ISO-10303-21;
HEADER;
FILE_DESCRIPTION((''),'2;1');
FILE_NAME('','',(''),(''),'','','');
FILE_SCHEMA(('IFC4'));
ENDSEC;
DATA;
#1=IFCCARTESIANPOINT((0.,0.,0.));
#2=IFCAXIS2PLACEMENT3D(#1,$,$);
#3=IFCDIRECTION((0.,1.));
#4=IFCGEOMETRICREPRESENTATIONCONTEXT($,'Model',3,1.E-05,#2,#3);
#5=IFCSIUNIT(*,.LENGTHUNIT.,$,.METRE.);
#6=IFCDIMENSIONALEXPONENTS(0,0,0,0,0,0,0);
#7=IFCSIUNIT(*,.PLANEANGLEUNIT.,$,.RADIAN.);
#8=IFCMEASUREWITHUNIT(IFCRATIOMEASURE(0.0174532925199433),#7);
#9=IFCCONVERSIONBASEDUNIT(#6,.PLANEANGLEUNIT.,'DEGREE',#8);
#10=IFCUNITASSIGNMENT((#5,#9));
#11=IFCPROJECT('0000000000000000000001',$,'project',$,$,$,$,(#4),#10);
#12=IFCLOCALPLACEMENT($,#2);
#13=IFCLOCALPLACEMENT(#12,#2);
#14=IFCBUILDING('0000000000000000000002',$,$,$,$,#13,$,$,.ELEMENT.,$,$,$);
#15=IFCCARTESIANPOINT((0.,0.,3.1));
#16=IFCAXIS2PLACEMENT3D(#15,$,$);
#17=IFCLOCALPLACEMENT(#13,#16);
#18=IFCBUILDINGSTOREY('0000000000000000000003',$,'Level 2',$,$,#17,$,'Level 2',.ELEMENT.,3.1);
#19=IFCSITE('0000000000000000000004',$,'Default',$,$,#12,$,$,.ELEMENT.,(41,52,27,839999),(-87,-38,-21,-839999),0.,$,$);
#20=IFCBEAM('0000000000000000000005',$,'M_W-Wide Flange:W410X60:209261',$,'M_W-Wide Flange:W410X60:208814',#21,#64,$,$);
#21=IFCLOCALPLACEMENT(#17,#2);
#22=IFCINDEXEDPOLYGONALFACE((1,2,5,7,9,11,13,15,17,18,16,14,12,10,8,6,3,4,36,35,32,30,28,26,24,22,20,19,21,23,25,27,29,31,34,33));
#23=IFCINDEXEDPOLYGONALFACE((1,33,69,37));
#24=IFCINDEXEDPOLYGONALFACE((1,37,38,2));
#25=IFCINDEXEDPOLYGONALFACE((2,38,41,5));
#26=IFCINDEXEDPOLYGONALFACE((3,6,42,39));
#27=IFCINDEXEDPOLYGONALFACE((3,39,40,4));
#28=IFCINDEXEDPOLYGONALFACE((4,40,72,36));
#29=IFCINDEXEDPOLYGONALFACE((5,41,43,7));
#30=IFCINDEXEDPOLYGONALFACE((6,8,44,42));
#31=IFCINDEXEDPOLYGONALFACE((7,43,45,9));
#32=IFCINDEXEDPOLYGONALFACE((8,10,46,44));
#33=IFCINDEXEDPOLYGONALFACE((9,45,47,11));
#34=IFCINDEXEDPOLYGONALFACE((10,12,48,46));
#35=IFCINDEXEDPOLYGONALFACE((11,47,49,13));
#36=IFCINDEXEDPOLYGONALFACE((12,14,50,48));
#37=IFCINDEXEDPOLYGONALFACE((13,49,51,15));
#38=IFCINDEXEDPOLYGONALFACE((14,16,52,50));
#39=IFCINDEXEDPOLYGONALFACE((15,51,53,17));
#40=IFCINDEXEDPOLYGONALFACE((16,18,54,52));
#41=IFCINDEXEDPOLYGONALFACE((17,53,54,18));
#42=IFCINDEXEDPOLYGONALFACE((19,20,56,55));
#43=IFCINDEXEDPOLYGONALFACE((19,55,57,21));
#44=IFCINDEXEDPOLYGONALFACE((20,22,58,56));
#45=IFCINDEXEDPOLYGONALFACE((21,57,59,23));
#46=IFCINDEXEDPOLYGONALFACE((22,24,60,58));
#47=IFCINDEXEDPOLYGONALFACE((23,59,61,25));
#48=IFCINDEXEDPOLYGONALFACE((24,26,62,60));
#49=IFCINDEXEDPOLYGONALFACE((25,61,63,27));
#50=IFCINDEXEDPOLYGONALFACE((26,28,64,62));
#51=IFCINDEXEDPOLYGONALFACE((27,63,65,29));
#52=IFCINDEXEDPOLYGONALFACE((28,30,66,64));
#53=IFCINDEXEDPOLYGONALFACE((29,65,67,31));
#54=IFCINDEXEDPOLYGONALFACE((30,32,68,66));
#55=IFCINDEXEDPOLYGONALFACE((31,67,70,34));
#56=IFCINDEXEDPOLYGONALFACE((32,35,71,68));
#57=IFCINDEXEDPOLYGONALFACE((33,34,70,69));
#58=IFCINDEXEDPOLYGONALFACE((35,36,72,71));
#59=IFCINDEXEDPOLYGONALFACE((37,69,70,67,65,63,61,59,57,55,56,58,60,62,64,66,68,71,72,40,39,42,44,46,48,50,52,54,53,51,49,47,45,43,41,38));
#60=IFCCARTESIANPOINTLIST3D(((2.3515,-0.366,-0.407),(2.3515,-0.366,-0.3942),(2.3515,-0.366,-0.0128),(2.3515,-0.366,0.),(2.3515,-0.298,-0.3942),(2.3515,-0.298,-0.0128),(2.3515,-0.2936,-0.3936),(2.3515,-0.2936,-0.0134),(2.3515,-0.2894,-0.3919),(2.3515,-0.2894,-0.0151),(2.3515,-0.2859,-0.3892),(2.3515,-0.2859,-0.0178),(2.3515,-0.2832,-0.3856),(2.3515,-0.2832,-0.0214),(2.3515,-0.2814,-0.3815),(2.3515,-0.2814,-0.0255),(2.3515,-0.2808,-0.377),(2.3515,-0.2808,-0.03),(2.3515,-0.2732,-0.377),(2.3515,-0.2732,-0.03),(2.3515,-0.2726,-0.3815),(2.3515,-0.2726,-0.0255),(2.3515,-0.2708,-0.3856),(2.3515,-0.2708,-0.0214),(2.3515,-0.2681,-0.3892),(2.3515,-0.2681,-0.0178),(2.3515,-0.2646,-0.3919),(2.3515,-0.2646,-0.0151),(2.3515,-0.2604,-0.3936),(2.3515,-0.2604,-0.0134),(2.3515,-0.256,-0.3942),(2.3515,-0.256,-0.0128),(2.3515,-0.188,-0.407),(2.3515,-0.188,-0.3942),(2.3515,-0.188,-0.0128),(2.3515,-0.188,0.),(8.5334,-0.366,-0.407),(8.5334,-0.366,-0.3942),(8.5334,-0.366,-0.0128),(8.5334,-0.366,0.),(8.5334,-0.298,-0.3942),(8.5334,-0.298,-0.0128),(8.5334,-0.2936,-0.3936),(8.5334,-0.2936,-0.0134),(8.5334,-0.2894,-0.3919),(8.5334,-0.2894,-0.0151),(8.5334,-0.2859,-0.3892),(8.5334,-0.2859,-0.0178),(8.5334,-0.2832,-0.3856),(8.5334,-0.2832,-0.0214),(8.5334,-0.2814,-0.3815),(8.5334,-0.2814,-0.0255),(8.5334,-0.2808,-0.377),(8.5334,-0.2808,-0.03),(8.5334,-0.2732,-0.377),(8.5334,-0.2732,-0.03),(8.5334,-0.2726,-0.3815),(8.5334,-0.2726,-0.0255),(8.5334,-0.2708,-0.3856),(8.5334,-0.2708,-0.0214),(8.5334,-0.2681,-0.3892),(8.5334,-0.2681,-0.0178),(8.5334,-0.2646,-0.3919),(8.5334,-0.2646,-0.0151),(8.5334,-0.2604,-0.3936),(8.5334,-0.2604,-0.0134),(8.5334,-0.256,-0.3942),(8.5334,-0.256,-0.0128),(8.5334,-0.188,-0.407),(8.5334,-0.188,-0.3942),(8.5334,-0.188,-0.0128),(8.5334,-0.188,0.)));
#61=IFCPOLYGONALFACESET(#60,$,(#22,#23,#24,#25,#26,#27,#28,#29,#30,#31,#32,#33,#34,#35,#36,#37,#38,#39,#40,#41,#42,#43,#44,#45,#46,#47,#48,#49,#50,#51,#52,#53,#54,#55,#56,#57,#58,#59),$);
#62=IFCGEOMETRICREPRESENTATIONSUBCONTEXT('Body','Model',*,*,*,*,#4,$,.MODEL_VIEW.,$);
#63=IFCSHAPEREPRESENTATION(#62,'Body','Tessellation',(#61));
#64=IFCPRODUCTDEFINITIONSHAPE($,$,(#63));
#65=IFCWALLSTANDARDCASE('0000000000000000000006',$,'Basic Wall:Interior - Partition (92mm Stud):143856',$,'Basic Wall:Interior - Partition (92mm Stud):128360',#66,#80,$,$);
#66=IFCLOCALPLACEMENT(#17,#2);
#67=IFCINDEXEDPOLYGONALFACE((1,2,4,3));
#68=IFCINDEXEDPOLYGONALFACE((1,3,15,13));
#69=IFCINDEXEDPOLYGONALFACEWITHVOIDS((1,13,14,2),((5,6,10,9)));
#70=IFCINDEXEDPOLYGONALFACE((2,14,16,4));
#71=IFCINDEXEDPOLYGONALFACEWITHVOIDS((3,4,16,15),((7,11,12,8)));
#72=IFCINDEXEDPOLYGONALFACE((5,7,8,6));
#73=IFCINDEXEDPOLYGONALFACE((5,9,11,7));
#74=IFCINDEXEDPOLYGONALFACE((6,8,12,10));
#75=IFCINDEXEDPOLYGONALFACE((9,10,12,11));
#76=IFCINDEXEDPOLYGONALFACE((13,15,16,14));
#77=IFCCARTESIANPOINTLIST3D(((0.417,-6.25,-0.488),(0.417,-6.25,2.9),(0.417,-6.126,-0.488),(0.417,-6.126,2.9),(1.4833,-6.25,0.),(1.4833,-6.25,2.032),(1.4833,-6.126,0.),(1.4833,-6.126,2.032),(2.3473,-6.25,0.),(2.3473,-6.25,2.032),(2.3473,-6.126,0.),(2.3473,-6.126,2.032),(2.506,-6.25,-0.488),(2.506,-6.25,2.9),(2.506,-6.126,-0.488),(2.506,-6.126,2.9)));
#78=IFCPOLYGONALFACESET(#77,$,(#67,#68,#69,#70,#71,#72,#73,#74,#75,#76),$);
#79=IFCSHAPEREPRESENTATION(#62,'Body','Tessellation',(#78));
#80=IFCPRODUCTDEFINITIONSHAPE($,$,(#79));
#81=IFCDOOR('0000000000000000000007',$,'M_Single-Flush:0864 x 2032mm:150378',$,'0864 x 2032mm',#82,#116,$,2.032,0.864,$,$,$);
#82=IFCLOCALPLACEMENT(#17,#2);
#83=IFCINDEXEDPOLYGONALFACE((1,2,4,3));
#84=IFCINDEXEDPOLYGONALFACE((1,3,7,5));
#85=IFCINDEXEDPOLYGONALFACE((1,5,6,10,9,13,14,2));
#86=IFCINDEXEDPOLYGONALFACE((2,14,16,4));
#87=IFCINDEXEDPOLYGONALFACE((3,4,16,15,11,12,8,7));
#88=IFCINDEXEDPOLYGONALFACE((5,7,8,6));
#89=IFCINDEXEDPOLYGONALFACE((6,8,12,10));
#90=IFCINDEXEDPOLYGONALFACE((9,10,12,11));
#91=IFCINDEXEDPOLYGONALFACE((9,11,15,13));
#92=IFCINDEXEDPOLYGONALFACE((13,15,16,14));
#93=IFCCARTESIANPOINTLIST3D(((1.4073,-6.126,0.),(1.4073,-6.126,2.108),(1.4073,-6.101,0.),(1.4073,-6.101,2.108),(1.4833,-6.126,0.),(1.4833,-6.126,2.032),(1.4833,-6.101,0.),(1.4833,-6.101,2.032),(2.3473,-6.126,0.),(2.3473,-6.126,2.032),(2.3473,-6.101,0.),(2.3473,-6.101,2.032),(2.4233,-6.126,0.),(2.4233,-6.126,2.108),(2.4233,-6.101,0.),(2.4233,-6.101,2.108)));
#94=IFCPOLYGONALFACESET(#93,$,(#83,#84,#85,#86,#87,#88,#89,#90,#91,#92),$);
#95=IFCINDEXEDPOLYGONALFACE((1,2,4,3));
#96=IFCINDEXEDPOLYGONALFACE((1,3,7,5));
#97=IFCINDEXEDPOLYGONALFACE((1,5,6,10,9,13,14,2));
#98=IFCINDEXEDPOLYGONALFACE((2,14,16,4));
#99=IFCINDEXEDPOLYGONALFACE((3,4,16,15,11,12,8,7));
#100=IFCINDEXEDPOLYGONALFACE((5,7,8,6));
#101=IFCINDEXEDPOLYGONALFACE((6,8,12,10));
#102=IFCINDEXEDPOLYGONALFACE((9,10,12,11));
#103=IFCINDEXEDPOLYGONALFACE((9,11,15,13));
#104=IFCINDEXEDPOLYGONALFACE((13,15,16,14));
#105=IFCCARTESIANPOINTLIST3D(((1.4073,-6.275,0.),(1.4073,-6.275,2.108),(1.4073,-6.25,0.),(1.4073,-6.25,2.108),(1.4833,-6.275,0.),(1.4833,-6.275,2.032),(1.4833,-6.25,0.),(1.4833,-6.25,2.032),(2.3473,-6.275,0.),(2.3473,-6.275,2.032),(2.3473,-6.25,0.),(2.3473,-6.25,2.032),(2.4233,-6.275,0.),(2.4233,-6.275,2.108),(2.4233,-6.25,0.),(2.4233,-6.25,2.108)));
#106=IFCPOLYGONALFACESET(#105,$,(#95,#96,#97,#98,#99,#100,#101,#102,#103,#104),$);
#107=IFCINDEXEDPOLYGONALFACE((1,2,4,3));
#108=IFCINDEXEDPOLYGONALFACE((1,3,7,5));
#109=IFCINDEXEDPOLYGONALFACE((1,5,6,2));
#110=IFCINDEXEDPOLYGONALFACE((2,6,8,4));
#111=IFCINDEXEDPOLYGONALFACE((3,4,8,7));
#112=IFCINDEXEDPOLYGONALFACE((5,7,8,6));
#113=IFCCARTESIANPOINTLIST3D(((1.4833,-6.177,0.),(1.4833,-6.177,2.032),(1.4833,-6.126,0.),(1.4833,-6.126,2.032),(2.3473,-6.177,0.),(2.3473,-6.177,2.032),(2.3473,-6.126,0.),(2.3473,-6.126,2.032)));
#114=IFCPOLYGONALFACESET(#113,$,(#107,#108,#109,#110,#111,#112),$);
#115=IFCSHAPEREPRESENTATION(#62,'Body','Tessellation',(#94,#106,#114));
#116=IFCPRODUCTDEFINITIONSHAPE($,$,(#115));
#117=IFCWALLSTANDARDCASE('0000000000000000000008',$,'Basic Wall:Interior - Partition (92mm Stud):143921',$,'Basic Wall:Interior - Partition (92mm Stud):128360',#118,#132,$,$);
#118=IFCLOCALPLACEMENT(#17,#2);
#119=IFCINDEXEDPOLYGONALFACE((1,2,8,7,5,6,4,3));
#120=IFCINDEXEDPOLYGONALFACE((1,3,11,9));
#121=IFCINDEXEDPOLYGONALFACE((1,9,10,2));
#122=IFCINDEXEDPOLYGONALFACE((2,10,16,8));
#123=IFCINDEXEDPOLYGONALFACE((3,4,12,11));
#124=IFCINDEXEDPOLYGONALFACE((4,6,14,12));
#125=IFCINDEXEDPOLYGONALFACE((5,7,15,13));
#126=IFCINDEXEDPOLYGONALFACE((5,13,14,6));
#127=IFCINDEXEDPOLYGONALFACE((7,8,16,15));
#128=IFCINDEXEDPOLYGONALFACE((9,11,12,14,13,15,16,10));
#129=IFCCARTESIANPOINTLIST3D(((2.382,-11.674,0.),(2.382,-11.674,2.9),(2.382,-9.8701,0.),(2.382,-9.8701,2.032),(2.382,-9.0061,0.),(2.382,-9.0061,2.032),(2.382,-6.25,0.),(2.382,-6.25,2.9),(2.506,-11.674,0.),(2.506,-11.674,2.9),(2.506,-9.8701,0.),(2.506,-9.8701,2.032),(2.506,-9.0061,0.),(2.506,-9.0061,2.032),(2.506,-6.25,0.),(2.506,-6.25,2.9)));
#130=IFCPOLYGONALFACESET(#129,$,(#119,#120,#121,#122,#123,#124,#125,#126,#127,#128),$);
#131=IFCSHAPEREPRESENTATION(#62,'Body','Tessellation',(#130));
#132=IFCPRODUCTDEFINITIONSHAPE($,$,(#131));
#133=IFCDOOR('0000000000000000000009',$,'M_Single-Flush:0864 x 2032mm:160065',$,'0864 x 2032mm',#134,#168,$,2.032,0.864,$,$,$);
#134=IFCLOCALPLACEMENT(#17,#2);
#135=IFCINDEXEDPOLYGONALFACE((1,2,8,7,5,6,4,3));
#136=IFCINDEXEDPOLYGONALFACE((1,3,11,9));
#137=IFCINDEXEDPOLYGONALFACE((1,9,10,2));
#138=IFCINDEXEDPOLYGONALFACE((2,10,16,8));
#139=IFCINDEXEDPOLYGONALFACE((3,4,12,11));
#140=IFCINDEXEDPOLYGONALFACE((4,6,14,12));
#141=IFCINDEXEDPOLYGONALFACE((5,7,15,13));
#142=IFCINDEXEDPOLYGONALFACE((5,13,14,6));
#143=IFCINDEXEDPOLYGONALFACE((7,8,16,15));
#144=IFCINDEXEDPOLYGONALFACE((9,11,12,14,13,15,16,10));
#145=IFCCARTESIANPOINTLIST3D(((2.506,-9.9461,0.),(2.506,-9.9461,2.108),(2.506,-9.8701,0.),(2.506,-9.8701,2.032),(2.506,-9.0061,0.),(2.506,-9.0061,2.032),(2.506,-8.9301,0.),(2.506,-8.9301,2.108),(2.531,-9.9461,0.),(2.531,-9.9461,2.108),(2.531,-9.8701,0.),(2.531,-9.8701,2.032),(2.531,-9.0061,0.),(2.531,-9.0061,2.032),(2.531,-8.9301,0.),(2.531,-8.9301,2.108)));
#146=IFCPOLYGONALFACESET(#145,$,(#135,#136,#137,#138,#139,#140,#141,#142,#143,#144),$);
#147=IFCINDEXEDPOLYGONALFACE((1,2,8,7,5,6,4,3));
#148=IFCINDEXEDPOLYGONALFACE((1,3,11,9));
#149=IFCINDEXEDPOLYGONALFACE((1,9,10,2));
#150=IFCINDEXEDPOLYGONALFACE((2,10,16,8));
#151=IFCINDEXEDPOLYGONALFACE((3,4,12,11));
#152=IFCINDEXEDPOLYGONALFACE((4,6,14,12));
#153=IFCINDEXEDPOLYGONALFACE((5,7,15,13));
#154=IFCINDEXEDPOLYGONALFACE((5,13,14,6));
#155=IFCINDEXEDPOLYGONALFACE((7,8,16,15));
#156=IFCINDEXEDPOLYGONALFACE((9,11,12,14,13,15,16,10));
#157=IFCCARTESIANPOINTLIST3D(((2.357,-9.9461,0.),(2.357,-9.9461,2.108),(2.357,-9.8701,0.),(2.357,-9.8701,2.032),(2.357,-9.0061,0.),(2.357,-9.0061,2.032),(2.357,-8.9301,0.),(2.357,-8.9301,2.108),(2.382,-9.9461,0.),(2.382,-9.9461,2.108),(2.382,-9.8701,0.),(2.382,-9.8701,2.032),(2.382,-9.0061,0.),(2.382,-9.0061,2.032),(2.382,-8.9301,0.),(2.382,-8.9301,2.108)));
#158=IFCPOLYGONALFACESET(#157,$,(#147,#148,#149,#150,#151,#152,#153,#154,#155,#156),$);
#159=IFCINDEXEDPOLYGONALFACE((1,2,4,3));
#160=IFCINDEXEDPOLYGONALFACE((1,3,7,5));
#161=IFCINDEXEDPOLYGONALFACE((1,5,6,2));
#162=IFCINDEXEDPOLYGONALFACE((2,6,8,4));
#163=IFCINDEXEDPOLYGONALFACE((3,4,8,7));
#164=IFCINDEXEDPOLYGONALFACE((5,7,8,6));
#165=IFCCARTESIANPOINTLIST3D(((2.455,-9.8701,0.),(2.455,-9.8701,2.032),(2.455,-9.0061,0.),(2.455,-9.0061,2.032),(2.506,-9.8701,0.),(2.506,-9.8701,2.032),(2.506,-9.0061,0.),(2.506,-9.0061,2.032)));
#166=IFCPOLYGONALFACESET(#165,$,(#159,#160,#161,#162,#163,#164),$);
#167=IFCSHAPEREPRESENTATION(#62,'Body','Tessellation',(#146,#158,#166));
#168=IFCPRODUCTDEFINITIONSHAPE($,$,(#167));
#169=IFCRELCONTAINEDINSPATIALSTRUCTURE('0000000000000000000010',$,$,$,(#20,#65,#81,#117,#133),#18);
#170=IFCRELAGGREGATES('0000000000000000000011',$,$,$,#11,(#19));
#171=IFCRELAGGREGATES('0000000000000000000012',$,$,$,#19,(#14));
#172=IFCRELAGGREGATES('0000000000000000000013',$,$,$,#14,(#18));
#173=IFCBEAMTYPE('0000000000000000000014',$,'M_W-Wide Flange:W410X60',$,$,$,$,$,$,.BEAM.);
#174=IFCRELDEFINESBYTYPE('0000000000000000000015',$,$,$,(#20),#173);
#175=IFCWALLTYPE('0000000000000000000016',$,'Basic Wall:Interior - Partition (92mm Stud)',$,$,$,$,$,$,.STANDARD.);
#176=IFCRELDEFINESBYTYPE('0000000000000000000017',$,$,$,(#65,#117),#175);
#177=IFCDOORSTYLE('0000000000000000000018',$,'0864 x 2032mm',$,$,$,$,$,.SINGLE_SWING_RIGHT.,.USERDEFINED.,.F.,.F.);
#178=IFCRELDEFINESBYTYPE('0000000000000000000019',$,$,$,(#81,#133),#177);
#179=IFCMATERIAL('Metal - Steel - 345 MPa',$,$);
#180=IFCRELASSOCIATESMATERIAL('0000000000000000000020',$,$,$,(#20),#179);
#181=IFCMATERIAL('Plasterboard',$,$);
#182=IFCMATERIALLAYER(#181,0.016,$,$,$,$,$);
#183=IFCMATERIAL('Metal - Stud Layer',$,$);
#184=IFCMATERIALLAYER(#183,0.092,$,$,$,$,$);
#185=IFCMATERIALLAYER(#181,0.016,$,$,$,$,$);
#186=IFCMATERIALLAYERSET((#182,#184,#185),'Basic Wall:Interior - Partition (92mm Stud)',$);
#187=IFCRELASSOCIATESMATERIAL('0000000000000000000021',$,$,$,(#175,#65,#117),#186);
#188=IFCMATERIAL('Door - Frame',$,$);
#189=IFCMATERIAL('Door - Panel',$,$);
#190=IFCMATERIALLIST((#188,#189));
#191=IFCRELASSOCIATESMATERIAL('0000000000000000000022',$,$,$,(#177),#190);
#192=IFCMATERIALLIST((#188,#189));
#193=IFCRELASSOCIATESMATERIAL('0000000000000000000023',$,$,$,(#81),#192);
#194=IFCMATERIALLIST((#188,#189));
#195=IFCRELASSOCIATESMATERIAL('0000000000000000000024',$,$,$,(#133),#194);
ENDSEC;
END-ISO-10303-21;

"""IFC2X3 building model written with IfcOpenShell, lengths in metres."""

from ifc_helpers import new_model, entity, si_unit, converted_unit, direction, frame, frame_2d, origin, origin_2d_with_axis, place, context, subcontext, project, spatial, polyline, rectangle, i_section, outline, extrude, source, transform, mapped, material, material_list, layer, layer_set, layer_usage, type_object, type_shapes, element, fill, save


model = new_model("IFC2X3")

# Units and contexts
model_context = context("Model", 3, precision=1e-05, world=origin(), true_north=direction((0.0, 1.0)))
body_context = subcontext(model_context, "Body", "Model", "MODEL_VIEW")
ifc_project = project(units=[si_unit("LENGTHUNIT", "METRE"), converted_unit("PLANEANGLEUNIT", "DEGREE", entity("IfcRatioMeasure", 0.0174532925199433), si_unit("PLANEANGLEUNIT", "RADIAN"), dimensions=[0, 0, 0, 0, 0, 0, 0])], contexts=[model_context])

# Site, building, storey
site_placement = place(None, origin())
site = spatial("IfcSite", under=ifc_project, at=site_placement, Name="Default", CompositionType="ELEMENT", RefLatitude=(41, 52, 27, 839999), RefLongitude=(-87, -38, -21, -839999), RefElevation=0.0)
building_placement = place(site_placement, origin())
building = spatial("IfcBuilding", under=site, at=building_placement, CompositionType="ELEMENT")
storey_placement = place(building_placement, frame((0.0, 0.0, 3.1)))
storey = spatial("IfcBuildingStorey", under=building, at=storey_placement, Name="Level 2", LongName="Level 2", CompositionType="ELEMENT", Elevation=3.1)

# Beam
ifc_material_1 = material(Name="Metal - Steel - 345 MPa")
beam_type = type_object("IfcBeamType", Name="M_W-Wide Flange:W410X60", PredefinedType="BEAM")
beam_placement = place(storey_placement, frame((8.5334, -0.277, 0.0), z_axis=(0.0, 0.0, 1.0), x_axis=(-1.0, 0.0, 0.0)))
element("IfcBeam", 1, at=beam_placement, inside=storey, type_object=beam_type, material=ifc_material_1, Name="M_W-Wide Flange:W410X60:209261", ObjectType="M_W-Wide Flange:W410X60:208814", context=body_context, shape_type="SweptSolid", body=[
    extrude(i_section(OverallWidth=0.178, OverallDepth=0.407, WebThickness=0.0077, FlangeThickness=0.0128, FilletRadius=0.0172, at=frame_2d((0.0, 0.0), x_axis=(0.0, 1.0))), frame((0.0, 0.0, -0.2035), z_axis=(1.0, 0.0, 0.0), x_axis=(0.0, 0.0, -1.0)), (0.0, 0.0, 1.0), 6.1819),
])

# Shared definitions
ifc_material_2 = material(Name="Metal - Stud Layer")
ifc_material_3 = material(Name="Plasterboard")

# Walls, openings, doors
ifc_layer_1 = layer(ifc_material_3, 0.016)
ifc_layer_2 = layer(ifc_material_2, 0.092)
ifc_layer_3 = layer(ifc_material_3, 0.016)
ifc_layer_set_1 = layer_set([ifc_layer_1, ifc_layer_2, ifc_layer_3], Name="Basic Wall:Interior - Partition (92mm Stud)")
ifc_layer_usage_1 = layer_usage(ifc_layer_set_1, "AXIS2", "NEGATIVE", 0.062)
wall_type_1 = type_object("IfcWallType", Name="Basic Wall:Interior - Partition (92mm Stud)", PredefinedType="STANDARD", material=ifc_layer_set_1)
wall_1_placement = place(storey_placement, frame((0.417, -6.188, -0.488)))
wall_1 = element("IfcWallStandardCase", 2, at=wall_1_placement, inside=storey, type_object=wall_type_1, material=ifc_layer_usage_1, Name="Basic Wall:Interior - Partition (92mm Stud):143856", ObjectType="Basic Wall:Interior - Partition (92mm Stud):128360", context=body_context, shape_type="SweptSolid", body=[
    extrude(rectangle(XDim=2.089, YDim=0.124, at=frame_2d((1.0445, 0.0), x_axis=(-1.0, 0.0))), origin(), (0.0, 0.0, 1.0), 3.388),
])
opening_1_placement = place(wall_1_placement, frame((1.0663, -0.062, 0.488)))
opening_1 = element("IfcOpeningElement", 3, at=opening_1_placement, cuts=wall_1, ObjectType="Opening", context=body_context, shape_type="SweptSolid", body=[
    extrude(rectangle(XDim=0.864, YDim=2.032, at=frame_2d((1.016, 0.432), x_axis=(0.0, 1.0))), frame((0.0, 0.0, 0.0), z_axis=(0.0, 1.0, 0.0), x_axis=(0.0, 0.0, 1.0)), (0.0, 0.0, 1.0), 0.124),
])
ifc_material_4 = material(Name="Door - Frame")
ifc_material_5 = material(Name="Door - Panel")
ifc_material_list_1 = material_list([ifc_material_4, ifc_material_5])
ifc_material_list_2 = material_list([ifc_material_4, ifc_material_5])
door_style_1 = type_object("IfcDoorStyle", Name="0864 x 2032mm", ConstructionType="USERDEFINED", OperationType="SINGLE_SWING_RIGHT", ParameterTakesPrecedence=False, Sizeable=False, material=ifc_material_list_2)
shared_shape_1 = source(origin(), body_context, "Body", "SweptSolid", [
    extrude(outline(polyline([(-0.508, -1.073), (0.508, -1.073), (0.508, 1.035), (0.432, 1.035), (0.432, -0.997), (-0.432, -0.997), (-0.432, 1.035), (-0.508, 1.035), (-0.508, -1.073)])), frame((0.432, 0.124, 1.035), z_axis=(0.0, 1.0, 0.0), x_axis=(1.0, 0.0, 0.0)), (0.0, 0.0, 1.0), 0.025),
    extrude(outline(polyline([(-1.073, -0.508), (1.035, -0.508), (1.035, -0.432), (-0.997, -0.432), (-0.997, 0.432), (1.035, 0.432), (1.035, 0.508), (-1.073, 0.508), (-1.073, -0.508)])), frame((0.432, -0.025, 1.035), z_axis=(0.0, 1.0, 0.0), x_axis=(0.0, 0.0, -1.0)), (0.0, 0.0, 1.0), 0.025),
    extrude(rectangle(XDim=0.051, YDim=0.864, at=origin_2d_with_axis()), frame((0.432, 0.0985, 0.0), z_axis=(0.0, 0.0, 1.0), x_axis=(0.0, 1.0, 0.0)), (0.0, 0.0, 1.0), 2.032),
])
type_shapes(door_style_1, [shared_shape_1])
door_1_placement = place(opening_1_placement, origin())
door_1 = element("IfcDoor", 4, at=door_1_placement, inside=storey, type_object=door_style_1, material=ifc_material_list_1, Name="M_Single-Flush:0864 x 2032mm:150378", ObjectType="0864 x 2032mm", OverallHeight=2.032, OverallWidth=0.864, context=body_context, shape_type="MappedRepresentation", body=[
    mapped(shared_shape_1, transform((0.0, 0.0, 0.0), scale=1.0)),
])
fill(opening_1, door_1)
ifc_layer_usage_2 = layer_usage(ifc_layer_set_1, "AXIS2", "NEGATIVE", 0.062)
wall_2_placement = place(storey_placement, frame((2.444, -6.25, 0.0), z_axis=(0.0, 0.0, 1.0), x_axis=(0.0, -1.0, 0.0)))
wall_2 = element("IfcWallStandardCase", 5, at=wall_2_placement, inside=storey, type_object=wall_type_1, material=ifc_layer_usage_2, Name="Basic Wall:Interior - Partition (92mm Stud):143921", ObjectType="Basic Wall:Interior - Partition (92mm Stud):128360", context=body_context, shape_type="SweptSolid", body=[
    extrude(rectangle(XDim=5.424, YDim=0.124, at=frame_2d((2.712, 0.0), x_axis=(-1.0, 0.0))), origin(), (0.0, 0.0, 1.0), 2.9),
])
opening_2_placement = place(wall_2_placement, frame((2.7561, -0.062, 0.0)))
opening_2 = element("IfcOpeningElement", 6, at=opening_2_placement, cuts=wall_2, ObjectType="Opening", context=body_context, shape_type="SweptSolid", body=[
    extrude(rectangle(XDim=0.864, YDim=2.032, at=frame_2d((1.016, 0.432), x_axis=(0.0, 1.0))), frame((0.0, 0.0, 0.0), z_axis=(0.0, 1.0, 0.0), x_axis=(0.0, 0.0, 1.0)), (0.0, 0.0, 1.0), 0.124),
])
ifc_material_list_3 = material_list([ifc_material_4, ifc_material_5])
door_2_placement = place(opening_2_placement, origin())
door_2 = element("IfcDoor", 7, at=door_2_placement, inside=storey, type_object=door_style_1, material=ifc_material_list_3, Name="M_Single-Flush:0864 x 2032mm:160065", ObjectType="0864 x 2032mm", OverallHeight=2.032, OverallWidth=0.864, context=body_context, shape_type="MappedRepresentation", body=[
    mapped(shared_shape_1, transform((0.0, 0.0, 0.0), scale=1.0)),
])
fill(opening_2, door_2)

save(model, "model.ifc")
